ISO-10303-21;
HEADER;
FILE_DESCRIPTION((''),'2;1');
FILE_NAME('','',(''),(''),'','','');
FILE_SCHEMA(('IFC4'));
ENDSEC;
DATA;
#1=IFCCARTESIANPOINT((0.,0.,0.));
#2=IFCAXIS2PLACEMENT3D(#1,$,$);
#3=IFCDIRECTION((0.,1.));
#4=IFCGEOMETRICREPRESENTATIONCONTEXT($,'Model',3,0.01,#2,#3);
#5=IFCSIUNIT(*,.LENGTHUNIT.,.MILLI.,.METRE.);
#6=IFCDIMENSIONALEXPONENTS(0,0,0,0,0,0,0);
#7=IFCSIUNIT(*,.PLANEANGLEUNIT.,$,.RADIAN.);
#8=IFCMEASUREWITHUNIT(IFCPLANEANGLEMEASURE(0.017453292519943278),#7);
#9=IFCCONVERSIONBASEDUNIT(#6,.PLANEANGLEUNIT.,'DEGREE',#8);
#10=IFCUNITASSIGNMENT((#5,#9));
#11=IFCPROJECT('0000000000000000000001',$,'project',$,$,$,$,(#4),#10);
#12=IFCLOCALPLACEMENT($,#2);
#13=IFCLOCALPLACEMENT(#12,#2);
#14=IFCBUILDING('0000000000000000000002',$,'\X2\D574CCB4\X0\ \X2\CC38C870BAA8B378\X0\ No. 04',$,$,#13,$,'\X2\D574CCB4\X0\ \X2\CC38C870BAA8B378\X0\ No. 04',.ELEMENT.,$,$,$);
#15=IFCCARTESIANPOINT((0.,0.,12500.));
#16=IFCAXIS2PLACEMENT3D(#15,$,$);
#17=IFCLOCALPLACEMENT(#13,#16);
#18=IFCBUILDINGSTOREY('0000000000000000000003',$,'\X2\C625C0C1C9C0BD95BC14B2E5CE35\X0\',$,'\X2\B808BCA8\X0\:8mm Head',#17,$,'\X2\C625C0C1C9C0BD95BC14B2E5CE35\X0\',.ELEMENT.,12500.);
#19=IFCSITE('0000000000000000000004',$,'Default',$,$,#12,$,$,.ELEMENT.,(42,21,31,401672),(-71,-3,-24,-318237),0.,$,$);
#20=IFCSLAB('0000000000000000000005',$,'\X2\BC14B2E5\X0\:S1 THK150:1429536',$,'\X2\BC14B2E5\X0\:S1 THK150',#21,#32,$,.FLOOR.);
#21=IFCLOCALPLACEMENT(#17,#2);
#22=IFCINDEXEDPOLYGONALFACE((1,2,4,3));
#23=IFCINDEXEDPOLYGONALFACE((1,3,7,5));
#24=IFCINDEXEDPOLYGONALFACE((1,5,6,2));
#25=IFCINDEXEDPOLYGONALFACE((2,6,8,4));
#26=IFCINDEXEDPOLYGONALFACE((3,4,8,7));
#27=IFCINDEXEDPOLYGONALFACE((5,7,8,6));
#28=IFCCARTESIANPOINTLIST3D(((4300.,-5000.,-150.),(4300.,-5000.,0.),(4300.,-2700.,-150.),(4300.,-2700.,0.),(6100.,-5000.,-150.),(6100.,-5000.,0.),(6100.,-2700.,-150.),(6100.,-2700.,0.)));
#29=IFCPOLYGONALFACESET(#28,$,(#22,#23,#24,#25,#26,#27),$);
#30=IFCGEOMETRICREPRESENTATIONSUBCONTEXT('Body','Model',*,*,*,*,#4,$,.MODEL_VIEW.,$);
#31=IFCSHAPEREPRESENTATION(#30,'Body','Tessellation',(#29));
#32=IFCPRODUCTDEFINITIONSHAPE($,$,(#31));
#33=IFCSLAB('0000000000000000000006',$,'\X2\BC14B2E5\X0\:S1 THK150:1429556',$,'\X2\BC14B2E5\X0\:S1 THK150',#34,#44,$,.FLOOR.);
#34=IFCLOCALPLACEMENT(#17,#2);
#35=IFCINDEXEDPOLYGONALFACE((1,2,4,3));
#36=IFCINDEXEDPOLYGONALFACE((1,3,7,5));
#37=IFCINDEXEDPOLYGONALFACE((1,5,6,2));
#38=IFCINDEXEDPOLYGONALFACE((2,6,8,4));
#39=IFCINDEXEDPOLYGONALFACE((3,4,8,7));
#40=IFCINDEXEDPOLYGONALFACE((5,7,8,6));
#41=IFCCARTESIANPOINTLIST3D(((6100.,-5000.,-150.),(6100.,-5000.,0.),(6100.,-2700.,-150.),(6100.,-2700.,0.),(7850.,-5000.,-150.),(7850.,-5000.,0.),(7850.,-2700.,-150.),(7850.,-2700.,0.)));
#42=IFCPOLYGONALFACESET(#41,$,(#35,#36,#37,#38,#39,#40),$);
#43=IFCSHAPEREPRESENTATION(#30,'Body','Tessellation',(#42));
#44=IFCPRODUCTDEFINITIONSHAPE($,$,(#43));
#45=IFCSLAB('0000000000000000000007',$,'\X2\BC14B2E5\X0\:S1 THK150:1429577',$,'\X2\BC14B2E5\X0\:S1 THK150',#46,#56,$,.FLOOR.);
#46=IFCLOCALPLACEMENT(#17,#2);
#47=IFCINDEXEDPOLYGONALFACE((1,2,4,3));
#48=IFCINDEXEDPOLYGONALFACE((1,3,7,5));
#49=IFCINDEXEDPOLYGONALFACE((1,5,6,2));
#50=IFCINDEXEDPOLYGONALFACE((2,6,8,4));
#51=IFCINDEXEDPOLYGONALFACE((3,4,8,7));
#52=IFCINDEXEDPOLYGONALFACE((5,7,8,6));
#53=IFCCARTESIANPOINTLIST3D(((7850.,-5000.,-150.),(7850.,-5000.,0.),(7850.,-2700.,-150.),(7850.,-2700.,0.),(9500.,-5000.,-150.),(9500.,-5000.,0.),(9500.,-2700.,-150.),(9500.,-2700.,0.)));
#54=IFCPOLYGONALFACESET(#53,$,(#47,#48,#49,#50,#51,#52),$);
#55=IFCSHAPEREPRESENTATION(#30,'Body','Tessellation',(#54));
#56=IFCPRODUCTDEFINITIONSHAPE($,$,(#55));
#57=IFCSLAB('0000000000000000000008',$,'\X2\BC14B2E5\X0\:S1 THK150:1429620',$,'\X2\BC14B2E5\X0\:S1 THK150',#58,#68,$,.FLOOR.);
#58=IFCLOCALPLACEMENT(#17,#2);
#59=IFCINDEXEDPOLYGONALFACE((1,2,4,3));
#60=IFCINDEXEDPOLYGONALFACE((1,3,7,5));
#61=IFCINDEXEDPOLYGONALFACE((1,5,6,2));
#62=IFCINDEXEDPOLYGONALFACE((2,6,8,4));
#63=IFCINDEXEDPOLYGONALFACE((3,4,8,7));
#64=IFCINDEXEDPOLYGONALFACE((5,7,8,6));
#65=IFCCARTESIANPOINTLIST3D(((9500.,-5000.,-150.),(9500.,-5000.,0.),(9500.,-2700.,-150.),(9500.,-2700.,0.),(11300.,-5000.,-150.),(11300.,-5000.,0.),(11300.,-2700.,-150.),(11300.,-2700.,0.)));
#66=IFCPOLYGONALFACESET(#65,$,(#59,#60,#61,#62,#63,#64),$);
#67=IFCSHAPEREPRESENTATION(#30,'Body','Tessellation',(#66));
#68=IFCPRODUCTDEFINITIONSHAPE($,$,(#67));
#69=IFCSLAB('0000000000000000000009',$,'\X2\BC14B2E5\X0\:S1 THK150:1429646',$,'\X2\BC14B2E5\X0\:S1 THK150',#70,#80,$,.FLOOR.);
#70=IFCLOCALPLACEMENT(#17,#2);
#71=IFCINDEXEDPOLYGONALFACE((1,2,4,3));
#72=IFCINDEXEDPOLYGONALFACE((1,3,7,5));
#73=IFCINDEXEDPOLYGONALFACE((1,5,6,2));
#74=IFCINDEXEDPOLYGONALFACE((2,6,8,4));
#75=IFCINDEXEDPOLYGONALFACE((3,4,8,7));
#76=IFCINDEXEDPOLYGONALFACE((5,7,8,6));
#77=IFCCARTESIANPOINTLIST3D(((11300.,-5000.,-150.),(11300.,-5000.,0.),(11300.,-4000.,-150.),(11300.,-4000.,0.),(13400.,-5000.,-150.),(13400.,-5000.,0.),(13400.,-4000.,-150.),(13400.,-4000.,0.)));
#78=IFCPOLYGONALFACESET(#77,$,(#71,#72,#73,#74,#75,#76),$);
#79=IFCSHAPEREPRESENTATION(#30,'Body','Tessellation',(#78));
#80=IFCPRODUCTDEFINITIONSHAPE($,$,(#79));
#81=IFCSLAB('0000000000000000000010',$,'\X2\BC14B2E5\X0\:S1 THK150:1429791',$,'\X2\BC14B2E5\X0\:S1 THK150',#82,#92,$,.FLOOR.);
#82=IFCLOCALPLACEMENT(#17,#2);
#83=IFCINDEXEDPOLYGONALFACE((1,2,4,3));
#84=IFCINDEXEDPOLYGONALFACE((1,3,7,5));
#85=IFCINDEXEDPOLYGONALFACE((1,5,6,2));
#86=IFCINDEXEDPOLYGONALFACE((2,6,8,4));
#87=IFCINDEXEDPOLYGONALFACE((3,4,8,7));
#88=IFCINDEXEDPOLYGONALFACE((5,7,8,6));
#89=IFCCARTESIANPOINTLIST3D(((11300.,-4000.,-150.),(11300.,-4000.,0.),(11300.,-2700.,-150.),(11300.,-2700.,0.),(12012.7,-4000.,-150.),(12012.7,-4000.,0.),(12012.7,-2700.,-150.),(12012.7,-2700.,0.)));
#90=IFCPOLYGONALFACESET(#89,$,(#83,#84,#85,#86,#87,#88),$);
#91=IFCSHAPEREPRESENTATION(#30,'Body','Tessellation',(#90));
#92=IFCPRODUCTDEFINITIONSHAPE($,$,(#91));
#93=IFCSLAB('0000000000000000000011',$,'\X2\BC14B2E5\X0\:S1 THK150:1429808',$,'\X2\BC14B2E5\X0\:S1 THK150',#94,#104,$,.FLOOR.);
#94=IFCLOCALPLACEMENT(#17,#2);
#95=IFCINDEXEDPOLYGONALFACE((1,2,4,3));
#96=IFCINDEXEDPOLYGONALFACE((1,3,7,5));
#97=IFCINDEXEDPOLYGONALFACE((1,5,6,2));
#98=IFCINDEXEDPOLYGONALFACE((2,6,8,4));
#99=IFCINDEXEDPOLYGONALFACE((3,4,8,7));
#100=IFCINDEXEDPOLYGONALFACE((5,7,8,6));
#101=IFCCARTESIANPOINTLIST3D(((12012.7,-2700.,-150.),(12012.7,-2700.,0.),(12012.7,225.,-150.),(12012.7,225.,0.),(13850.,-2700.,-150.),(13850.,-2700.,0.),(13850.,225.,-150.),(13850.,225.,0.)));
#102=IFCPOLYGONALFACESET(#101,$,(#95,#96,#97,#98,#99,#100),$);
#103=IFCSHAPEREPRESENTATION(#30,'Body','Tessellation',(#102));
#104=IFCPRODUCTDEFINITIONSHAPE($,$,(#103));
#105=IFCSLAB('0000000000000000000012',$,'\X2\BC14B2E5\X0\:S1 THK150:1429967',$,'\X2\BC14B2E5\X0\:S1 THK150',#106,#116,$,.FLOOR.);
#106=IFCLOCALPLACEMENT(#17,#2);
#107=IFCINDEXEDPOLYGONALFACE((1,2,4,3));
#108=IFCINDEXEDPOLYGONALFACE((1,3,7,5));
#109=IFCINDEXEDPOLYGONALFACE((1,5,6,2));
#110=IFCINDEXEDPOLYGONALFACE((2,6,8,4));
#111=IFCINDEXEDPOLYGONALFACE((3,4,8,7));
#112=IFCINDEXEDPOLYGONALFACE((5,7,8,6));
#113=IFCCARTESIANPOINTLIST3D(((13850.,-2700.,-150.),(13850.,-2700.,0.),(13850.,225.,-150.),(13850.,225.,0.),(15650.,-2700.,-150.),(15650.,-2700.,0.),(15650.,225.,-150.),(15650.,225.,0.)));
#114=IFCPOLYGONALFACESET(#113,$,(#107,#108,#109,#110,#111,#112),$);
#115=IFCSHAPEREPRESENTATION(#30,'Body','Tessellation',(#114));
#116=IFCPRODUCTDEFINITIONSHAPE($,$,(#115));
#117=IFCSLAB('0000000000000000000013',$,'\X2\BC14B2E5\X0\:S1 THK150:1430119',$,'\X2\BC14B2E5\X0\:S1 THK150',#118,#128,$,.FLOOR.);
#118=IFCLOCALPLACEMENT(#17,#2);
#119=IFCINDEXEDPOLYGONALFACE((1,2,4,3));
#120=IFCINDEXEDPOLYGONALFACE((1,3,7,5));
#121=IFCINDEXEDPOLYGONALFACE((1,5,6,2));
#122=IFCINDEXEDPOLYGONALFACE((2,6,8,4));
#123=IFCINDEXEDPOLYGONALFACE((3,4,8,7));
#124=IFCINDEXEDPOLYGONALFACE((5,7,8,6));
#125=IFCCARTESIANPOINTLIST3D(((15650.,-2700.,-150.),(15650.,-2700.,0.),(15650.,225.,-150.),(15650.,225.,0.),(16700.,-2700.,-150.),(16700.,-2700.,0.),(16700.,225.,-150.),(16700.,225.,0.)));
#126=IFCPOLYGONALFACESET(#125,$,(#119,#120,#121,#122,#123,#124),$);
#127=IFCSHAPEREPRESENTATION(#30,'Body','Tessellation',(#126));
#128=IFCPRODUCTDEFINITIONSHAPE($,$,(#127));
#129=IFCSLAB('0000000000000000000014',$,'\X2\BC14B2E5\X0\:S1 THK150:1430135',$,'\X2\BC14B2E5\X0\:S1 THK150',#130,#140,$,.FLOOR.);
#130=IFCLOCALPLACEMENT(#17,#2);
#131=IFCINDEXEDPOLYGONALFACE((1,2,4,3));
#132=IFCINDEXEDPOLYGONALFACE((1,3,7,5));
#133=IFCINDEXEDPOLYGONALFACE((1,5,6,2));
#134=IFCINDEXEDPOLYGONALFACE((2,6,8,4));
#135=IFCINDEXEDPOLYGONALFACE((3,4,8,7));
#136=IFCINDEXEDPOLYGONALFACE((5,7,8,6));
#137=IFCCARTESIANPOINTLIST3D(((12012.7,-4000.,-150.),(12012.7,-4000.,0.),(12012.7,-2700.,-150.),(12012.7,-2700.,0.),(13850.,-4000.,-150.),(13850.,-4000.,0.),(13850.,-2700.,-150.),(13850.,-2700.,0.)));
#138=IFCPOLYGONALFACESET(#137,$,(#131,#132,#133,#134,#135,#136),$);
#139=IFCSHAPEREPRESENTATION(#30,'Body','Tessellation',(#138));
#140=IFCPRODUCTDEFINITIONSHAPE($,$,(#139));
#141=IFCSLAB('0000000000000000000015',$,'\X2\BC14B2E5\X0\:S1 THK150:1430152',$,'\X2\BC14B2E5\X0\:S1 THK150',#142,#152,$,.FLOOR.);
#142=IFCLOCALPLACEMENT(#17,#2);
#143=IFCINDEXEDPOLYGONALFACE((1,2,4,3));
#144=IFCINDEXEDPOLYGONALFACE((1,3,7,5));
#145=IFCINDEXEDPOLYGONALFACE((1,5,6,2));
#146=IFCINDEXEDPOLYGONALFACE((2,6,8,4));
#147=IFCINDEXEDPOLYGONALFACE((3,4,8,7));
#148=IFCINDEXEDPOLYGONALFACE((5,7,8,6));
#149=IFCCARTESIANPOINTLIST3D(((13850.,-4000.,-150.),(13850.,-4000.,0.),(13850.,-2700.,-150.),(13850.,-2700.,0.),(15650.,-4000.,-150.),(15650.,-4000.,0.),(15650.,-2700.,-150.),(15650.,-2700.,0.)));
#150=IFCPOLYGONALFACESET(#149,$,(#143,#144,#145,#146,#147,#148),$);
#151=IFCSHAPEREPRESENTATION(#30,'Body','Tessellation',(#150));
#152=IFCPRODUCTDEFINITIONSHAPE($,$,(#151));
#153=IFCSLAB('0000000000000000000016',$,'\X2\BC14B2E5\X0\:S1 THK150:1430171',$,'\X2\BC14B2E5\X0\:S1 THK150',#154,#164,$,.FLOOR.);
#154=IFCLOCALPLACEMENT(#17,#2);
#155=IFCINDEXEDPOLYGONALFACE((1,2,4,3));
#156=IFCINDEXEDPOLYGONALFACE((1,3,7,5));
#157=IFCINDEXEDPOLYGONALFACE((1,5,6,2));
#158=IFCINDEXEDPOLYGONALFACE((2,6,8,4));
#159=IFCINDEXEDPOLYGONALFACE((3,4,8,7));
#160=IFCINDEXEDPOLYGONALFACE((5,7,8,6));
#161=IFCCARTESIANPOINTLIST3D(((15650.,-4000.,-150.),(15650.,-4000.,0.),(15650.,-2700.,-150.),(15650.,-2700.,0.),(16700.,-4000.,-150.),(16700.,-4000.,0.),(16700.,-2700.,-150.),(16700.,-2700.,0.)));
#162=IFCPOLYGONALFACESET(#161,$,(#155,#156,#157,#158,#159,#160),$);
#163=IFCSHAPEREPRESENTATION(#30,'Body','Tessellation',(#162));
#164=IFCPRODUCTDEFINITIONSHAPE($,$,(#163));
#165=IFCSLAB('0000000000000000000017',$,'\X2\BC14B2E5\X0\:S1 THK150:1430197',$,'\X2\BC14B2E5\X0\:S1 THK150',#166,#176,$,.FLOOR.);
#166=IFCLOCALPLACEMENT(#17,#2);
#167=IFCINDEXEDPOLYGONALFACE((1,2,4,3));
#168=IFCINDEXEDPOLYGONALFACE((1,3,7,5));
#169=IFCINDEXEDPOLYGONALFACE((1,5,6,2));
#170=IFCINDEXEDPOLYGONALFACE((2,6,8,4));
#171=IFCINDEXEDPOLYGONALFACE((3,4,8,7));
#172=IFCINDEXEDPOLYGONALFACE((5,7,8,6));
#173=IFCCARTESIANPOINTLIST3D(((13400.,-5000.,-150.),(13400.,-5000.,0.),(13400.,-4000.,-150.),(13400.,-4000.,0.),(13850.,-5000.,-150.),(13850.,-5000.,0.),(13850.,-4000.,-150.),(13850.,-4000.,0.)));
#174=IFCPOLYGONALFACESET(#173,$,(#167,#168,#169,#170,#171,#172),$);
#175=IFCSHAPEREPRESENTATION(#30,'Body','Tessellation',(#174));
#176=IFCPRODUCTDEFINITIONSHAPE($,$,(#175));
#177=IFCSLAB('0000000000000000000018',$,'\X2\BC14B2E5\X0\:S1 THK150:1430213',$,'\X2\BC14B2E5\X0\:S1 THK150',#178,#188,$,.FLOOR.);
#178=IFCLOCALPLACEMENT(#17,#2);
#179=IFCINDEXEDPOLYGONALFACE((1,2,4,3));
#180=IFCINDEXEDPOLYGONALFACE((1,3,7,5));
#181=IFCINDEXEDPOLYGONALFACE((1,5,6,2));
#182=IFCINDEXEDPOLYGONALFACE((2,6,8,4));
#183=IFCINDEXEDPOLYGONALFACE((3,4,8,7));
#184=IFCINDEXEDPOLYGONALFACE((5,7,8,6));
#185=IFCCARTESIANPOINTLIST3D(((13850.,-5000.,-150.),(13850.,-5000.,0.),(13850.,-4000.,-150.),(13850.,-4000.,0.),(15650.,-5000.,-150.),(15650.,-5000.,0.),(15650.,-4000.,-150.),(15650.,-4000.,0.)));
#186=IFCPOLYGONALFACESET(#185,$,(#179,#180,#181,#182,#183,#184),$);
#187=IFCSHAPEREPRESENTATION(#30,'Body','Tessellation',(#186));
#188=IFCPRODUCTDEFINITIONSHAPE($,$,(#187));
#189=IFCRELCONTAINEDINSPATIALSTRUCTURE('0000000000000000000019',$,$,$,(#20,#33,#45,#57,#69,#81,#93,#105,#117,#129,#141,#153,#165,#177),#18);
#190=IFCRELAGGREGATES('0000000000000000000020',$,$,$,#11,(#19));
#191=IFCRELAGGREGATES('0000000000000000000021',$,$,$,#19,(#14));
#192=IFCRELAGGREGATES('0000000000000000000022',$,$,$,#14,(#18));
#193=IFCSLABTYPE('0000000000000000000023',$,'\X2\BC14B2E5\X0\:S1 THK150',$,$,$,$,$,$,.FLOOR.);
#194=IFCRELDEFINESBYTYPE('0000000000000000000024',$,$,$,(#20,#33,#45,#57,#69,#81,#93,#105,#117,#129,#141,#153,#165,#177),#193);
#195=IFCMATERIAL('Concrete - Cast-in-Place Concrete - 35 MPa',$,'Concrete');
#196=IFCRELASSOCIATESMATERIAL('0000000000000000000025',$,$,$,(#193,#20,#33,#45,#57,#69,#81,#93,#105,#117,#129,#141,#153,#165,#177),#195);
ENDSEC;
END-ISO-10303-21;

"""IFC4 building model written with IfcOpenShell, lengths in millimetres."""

from ifc_helpers import new_model, entity, si_unit, converted_unit, direction, frame, origin, place, context, subcontext, project, spatial, indexed_curve, outline, extrude, material, type_object, element, save


model = new_model("IFC4")

# Units and contexts
model_context = context("Model", 3, precision=0.01, world=origin(), true_north=direction((0.0, 1.0)))
body_context = subcontext(model_context, "Body", "Model", "MODEL_VIEW")
ifc_project = project(units=[si_unit("LENGTHUNIT", "METRE", prefix="MILLI"), converted_unit("PLANEANGLEUNIT", "DEGREE", entity("IfcPlaneAngleMeasure", 0.017453292519943278), si_unit("PLANEANGLEUNIT", "RADIAN"), dimensions=[0, 0, 0, 0, 0, 0, 0])], contexts=[model_context])

# Site, building, storey
site_placement = place(None, origin())
site = spatial("IfcSite", under=ifc_project, at=site_placement, Name="Default", CompositionType="ELEMENT", RefLatitude=(42, 21, 31, 401672), RefLongitude=(-71, -3, -24, -318237), RefElevation=0.0)
building_placement = place(site_placement, origin())
building = spatial("IfcBuilding", under=site, at=building_placement, Name="해체 참조모델 No. 04", LongName="해체 참조모델 No. 04", CompositionType="ELEMENT")
storey_placement = place(building_placement, frame((0.0, 0.0, 12500.0)))
storey = spatial("IfcBuildingStorey", under=building, at=storey_placement, Name="옥상지붕바닥층", ObjectType="레벨:8mm Head", LongName="옥상지붕바닥층", CompositionType="ELEMENT", Elevation=12500.0)

# Slabs
ifc_material = material(Name="Concrete - Cast-in-Place Concrete - 35 MPa", Category="Concrete")
slab_type_1 = type_object("IfcSlabType", Name="바닥:S1 THK150", PredefinedType="FLOOR", material=ifc_material)
slab_1_placement = place(storey_placement, origin())
element("IfcSlab", 1, at=slab_1_placement, inside=storey, type_object=slab_type_1, material=ifc_material, Name="바닥:S1 THK150:1429536", ObjectType="바닥:S1 THK150", PredefinedType="FLOOR", context=body_context, shape_type="SweptSolid", body=[
    extrude(outline(indexed_curve([(-1150.0, -900.0), (1150.0, -900.0), (1150.0, 900.0), (-1150.0, 900.0), (-1150.0, -900.0)], self_intersect=False)), frame((5200.0, -3850.0, 0.0), z_axis=(0.0, 0.0, -1.0), x_axis=(0.0, 1.0, 0.0)), (0.0, 0.0, 1.0), 150.0),
])
slab_2_placement = place(storey_placement, origin())
element("IfcSlab", 2, at=slab_2_placement, inside=storey, type_object=slab_type_1, material=ifc_material, Name="바닥:S1 THK150:1429556", ObjectType="바닥:S1 THK150", PredefinedType="FLOOR", context=body_context, shape_type="SweptSolid", body=[
    extrude(outline(indexed_curve([(-1150.0, -875.0), (1150.0, -875.0), (1150.0, 875.0), (-1150.0, 875.0), (-1150.0, -875.0)], self_intersect=False)), frame((6975.0, -3850.0, 0.0), z_axis=(0.0, 0.0, -1.0), x_axis=(0.0, 1.0, 0.0)), (0.0, 0.0, 1.0), 150.0),
])
slab_3_placement = place(storey_placement, origin())
element("IfcSlab", 3, at=slab_3_placement, inside=storey, type_object=slab_type_1, material=ifc_material, Name="바닥:S1 THK150:1429577", ObjectType="바닥:S1 THK150", PredefinedType="FLOOR", context=body_context, shape_type="SweptSolid", body=[
    extrude(outline(indexed_curve([(-1150.0, -825.0), (1150.0, -825.0), (1150.0, 825.0), (-1150.0, 825.0), (-1150.0, -825.0)], self_intersect=False)), frame((8675.0, -3850.0, 0.0), z_axis=(0.0, 0.0, -1.0), x_axis=(0.0, 1.0, 0.0)), (0.0, 0.0, 1.0), 150.0),
])
slab_4_placement = place(storey_placement, origin())
element("IfcSlab", 4, at=slab_4_placement, inside=storey, type_object=slab_type_1, material=ifc_material, Name="바닥:S1 THK150:1429620", ObjectType="바닥:S1 THK150", PredefinedType="FLOOR", context=body_context, shape_type="SweptSolid", body=[
    extrude(outline(indexed_curve([(-1150.0, -900.0), (1150.0, -900.0), (1150.0, 900.0), (-1150.0, 900.0), (-1150.0, -900.0)], self_intersect=False)), frame((10400.0, -3850.0, 0.0), z_axis=(0.0, 0.0, -1.0), x_axis=(0.0, 1.0, 0.0)), (0.0, 0.0, 1.0), 150.0),
])
slab_5_placement = place(storey_placement, origin())
element("IfcSlab", 5, at=slab_5_placement, inside=storey, type_object=slab_type_1, material=ifc_material, Name="바닥:S1 THK150:1429646", ObjectType="바닥:S1 THK150", PredefinedType="FLOOR", context=body_context, shape_type="SweptSolid", body=[
    extrude(outline(indexed_curve([(-500.0, -1050.0), (500.0, -1050.0), (500.0, 1050.0), (-500.0, 1050.0), (-500.0, -1050.0)], self_intersect=False)), frame((12350.0, -4500.0, 0.0), z_axis=(0.0, 0.0, -1.0), x_axis=(0.0, 1.0, 0.0)), (0.0, 0.0, 1.0), 150.0),
])
slab_6_placement = place(storey_placement, origin())
element("IfcSlab", 6, at=slab_6_placement, inside=storey, type_object=slab_type_1, material=ifc_material, Name="바닥:S1 THK150:1429791", ObjectType="바닥:S1 THK150", PredefinedType="FLOOR", context=body_context, shape_type="SweptSolid", body=[
    extrude(outline(indexed_curve([(-650.0, -356.4), (650.0, -356.4), (650.0, 356.4), (-650.0, 356.4), (-650.0, -356.4)], self_intersect=False)), frame((11656.4, -3350.0, 0.0), z_axis=(0.0, 0.0, -1.0), x_axis=(0.0, 1.0, 0.0)), (0.0, 0.0, 1.0), 150.0),
])
slab_7_placement = place(storey_placement, origin())
element("IfcSlab", 7, at=slab_7_placement, inside=storey, type_object=slab_type_1, material=ifc_material, Name="바닥:S1 THK150:1429808", ObjectType="바닥:S1 THK150", PredefinedType="FLOOR", context=body_context, shape_type="SweptSolid", body=[
    extrude(outline(indexed_curve([(-1462.5, -918.7), (1462.5, -918.7), (1462.5, 918.6), (-1462.5, 918.6), (-1462.5, -918.7)], self_intersect=False)), frame((12931.4, -1237.5, 0.0), z_axis=(0.0, 0.0, -1.0), x_axis=(0.0, 1.0, 0.0)), (0.0, 0.0, 1.0), 150.0),
])
slab_8_placement = place(storey_placement, origin())
element("IfcSlab", 8, at=slab_8_placement, inside=storey, type_object=slab_type_1, material=ifc_material, Name="바닥:S1 THK150:1429967", ObjectType="바닥:S1 THK150", PredefinedType="FLOOR", context=body_context, shape_type="SweptSolid", body=[
    extrude(outline(indexed_curve([(-1462.5, -900.0), (1462.5, -900.0), (1462.5, 900.0), (-1462.5, 900.0), (-1462.5, -900.0)], self_intersect=False)), frame((14750.0, -1237.5, 0.0), z_axis=(0.0, 0.0, -1.0), x_axis=(0.0, 1.0, 0.0)), (0.0, 0.0, 1.0), 150.0),
])
slab_9_placement = place(storey_placement, origin())
element("IfcSlab", 9, at=slab_9_placement, inside=storey, type_object=slab_type_1, material=ifc_material, Name="바닥:S1 THK150:1430119", ObjectType="바닥:S1 THK150", PredefinedType="FLOOR", context=body_context, shape_type="SweptSolid", body=[
    extrude(outline(indexed_curve([(-1462.5, -525.0), (1462.5, -525.0), (1462.5, 525.0), (-1462.5, 525.0), (-1462.5, -525.0)], self_intersect=False)), frame((16175.0, -1237.5, 0.0), z_axis=(0.0, 0.0, -1.0), x_axis=(0.0, 1.0, 0.0)), (0.0, 0.0, 1.0), 150.0),
])
slab_10_placement = place(storey_placement, origin())
element("IfcSlab", 10, at=slab_10_placement, inside=storey, type_object=slab_type_1, material=ifc_material, Name="바닥:S1 THK150:1430135", ObjectType="바닥:S1 THK150", PredefinedType="FLOOR", context=body_context, shape_type="SweptSolid", body=[
    extrude(outline(indexed_curve([(-650.0, -918.7), (650.0, -918.7), (650.0, 918.6), (-650.0, 918.6), (-650.0, -918.7)], self_intersect=False)), frame((12931.4, -3350.0, 0.0), z_axis=(0.0, 0.0, -1.0), x_axis=(0.0, 1.0, 0.0)), (0.0, 0.0, 1.0), 150.0),
])
slab_11_placement = place(storey_placement, origin())
element("IfcSlab", 11, at=slab_11_placement, inside=storey, type_object=slab_type_1, material=ifc_material, Name="바닥:S1 THK150:1430152", ObjectType="바닥:S1 THK150", PredefinedType="FLOOR", context=body_context, shape_type="SweptSolid", body=[
    extrude(outline(indexed_curve([(-650.0, -900.0), (650.0, -900.0), (650.0, 900.0), (-650.0, 900.0), (-650.0, -900.0)], self_intersect=False)), frame((14750.0, -3350.0, 0.0), z_axis=(0.0, 0.0, -1.0), x_axis=(0.0, 1.0, 0.0)), (0.0, 0.0, 1.0), 150.0),
])
slab_12_placement = place(storey_placement, origin())
element("IfcSlab", 12, at=slab_12_placement, inside=storey, type_object=slab_type_1, material=ifc_material, Name="바닥:S1 THK150:1430171", ObjectType="바닥:S1 THK150", PredefinedType="FLOOR", context=body_context, shape_type="SweptSolid", body=[
    extrude(outline(indexed_curve([(-650.0, -525.0), (650.0, -525.0), (650.0, 525.0), (-650.0, 525.0), (-650.0, -525.0)], self_intersect=False)), frame((16175.0, -3350.0, 0.0), z_axis=(0.0, 0.0, -1.0), x_axis=(0.0, 1.0, 0.0)), (0.0, 0.0, 1.0), 150.0),
])
slab_13_placement = place(storey_placement, origin())
element("IfcSlab", 13, at=slab_13_placement, inside=storey, type_object=slab_type_1, material=ifc_material, Name="바닥:S1 THK150:1430197", ObjectType="바닥:S1 THK150", PredefinedType="FLOOR", context=body_context, shape_type="SweptSolid", body=[
    extrude(outline(indexed_curve([(-500.0, -225.0), (500.0, -225.0), (500.0, 225.0), (-500.0, 225.0), (-500.0, -225.0)], self_intersect=False)), frame((13625.0, -4500.0, 0.0), z_axis=(0.0, 0.0, -1.0), x_axis=(0.0, 1.0, 0.0)), (0.0, 0.0, 1.0), 150.0),
])
slab_14_placement = place(storey_placement, origin())
element("IfcSlab", 14, at=slab_14_placement, inside=storey, type_object=slab_type_1, material=ifc_material, Name="바닥:S1 THK150:1430213", ObjectType="바닥:S1 THK150", PredefinedType="FLOOR", context=body_context, shape_type="SweptSolid", body=[
    extrude(outline(indexed_curve([(-500.0, -900.0), (500.0, -900.0), (500.0, 900.0), (-500.0, 900.0), (-500.0, -900.0)], self_intersect=False)), frame((14750.0, -4500.0, 0.0), z_axis=(0.0, 0.0, -1.0), x_axis=(0.0, 1.0, 0.0)), (0.0, 0.0, 1.0), 150.0),
])

save(model, "model.ifc")
